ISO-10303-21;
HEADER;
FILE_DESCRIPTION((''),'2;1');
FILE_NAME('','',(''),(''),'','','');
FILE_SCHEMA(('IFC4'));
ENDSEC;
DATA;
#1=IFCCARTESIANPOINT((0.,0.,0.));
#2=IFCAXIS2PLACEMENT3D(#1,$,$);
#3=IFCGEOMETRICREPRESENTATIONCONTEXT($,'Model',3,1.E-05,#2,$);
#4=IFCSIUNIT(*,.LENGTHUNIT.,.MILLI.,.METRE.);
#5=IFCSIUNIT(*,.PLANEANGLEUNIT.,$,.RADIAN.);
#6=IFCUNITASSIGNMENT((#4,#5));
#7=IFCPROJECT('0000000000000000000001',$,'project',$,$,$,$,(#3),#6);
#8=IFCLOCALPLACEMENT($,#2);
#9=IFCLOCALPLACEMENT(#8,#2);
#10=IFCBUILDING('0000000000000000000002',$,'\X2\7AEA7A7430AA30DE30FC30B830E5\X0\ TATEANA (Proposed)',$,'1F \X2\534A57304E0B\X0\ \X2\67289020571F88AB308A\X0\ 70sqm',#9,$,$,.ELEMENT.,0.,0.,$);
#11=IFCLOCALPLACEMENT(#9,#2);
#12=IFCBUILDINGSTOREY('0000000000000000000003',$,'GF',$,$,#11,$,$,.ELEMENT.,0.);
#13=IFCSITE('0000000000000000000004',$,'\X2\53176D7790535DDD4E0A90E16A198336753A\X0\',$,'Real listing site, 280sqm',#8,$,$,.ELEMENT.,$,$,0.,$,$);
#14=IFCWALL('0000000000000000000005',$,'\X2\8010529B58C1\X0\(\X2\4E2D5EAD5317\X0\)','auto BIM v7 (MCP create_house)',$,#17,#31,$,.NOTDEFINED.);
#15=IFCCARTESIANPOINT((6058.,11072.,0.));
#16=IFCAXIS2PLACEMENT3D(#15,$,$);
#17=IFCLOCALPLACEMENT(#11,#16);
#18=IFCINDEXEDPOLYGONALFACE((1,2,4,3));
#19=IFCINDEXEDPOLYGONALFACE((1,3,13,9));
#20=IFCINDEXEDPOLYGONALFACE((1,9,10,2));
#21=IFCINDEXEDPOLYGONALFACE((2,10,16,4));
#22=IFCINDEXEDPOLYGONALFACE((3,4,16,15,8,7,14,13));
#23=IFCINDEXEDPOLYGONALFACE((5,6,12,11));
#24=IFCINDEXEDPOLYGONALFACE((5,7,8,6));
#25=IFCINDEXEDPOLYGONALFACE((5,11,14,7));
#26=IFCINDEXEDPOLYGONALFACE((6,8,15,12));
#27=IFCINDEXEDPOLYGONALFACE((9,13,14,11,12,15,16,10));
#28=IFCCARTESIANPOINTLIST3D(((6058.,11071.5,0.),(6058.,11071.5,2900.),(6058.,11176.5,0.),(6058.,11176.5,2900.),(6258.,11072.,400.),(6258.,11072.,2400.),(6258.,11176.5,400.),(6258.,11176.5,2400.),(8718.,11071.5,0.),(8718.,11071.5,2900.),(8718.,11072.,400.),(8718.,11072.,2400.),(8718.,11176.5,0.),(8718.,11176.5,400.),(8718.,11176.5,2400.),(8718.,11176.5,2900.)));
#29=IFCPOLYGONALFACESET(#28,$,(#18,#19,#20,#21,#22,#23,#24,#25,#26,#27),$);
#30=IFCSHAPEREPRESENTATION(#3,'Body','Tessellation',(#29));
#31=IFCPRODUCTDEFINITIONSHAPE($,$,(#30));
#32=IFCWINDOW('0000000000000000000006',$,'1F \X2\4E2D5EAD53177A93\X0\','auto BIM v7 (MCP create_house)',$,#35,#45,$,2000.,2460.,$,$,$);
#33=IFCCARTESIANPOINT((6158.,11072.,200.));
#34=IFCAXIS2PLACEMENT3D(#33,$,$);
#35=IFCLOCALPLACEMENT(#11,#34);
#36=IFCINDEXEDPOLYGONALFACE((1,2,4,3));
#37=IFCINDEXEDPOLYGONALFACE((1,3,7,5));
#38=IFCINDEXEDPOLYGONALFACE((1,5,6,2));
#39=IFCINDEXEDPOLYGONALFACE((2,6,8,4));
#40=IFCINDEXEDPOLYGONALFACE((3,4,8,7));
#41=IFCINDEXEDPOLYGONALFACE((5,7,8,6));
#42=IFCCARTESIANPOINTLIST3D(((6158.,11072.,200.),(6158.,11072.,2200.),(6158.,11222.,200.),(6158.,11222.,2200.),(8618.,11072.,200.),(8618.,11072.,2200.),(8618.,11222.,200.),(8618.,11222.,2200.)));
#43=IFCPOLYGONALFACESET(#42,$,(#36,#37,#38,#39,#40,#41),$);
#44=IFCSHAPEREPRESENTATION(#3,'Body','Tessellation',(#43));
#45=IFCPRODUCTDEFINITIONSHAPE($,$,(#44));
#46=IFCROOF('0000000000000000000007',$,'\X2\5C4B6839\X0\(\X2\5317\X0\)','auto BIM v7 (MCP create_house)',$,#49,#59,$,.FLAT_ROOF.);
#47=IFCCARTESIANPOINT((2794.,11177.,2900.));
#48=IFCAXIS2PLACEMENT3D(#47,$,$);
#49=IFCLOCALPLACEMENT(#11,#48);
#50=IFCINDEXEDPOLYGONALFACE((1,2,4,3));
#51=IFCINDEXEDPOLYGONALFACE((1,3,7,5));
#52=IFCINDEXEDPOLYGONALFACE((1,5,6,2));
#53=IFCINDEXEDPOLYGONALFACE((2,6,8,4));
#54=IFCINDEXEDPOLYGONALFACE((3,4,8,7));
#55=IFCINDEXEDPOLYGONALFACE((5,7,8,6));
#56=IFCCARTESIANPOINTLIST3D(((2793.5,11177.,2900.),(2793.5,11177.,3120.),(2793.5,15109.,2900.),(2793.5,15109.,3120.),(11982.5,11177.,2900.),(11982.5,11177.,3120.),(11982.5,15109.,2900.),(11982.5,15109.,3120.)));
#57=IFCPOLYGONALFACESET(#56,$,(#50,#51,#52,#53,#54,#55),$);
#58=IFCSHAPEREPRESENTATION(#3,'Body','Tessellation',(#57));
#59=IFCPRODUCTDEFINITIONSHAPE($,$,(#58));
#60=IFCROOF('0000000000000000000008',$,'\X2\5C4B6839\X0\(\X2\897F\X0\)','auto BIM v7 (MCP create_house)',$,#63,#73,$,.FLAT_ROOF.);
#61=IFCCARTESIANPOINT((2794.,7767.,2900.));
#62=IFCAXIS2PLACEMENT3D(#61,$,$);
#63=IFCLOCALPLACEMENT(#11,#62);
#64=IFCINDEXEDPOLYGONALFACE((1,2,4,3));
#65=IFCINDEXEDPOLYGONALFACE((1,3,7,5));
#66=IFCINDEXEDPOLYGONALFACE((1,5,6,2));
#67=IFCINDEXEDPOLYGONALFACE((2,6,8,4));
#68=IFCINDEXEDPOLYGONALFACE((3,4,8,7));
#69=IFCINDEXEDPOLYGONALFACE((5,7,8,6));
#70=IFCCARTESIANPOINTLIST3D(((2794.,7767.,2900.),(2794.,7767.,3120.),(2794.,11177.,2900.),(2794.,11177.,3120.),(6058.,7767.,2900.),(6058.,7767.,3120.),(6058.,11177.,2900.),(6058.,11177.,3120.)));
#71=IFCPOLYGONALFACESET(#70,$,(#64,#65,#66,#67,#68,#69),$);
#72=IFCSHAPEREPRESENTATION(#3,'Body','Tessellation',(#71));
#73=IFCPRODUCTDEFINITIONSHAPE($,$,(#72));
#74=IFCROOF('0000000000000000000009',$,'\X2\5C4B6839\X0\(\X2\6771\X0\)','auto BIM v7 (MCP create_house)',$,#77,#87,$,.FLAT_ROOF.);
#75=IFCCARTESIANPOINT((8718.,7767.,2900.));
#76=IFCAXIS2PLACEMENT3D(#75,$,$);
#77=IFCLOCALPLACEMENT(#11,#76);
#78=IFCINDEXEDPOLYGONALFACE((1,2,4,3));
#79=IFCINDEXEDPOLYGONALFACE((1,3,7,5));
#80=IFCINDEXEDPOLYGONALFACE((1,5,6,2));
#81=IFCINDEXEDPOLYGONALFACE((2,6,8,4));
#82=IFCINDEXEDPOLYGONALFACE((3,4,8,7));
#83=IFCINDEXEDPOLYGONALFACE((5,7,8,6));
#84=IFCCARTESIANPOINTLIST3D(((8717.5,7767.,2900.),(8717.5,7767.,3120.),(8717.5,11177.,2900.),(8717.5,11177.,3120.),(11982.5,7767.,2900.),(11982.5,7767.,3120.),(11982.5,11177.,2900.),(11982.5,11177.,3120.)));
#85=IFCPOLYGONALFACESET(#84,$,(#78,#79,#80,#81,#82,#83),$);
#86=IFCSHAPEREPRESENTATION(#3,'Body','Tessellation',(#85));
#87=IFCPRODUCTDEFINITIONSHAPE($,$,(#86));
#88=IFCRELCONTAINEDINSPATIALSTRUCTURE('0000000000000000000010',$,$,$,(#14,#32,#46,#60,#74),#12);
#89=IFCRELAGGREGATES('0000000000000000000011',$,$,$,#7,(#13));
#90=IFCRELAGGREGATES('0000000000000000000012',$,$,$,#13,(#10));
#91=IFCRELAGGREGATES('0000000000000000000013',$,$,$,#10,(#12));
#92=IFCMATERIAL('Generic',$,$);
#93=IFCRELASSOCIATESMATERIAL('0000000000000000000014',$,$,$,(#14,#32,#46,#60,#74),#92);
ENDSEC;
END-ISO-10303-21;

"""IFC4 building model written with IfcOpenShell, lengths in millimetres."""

from ifc_helpers import new_model, si_unit, frame, frame_2d, origin, place, context, project, spatial, rectangle, extrude, material, element, fill, save


model = new_model("IFC4")

# Units and contexts
model_context = context("Model", 3, precision=1e-05, world=origin())
ifc_project = project(units=[si_unit("LENGTHUNIT", "METRE", prefix="MILLI"), si_unit("PLANEANGLEUNIT", "RADIAN")], contexts=[model_context])

# Site, building, storey
site_placement = place(None, origin())
site = spatial("IfcSite", under=ifc_project, at=site_placement, Name="北海道川上郡標茶町", ObjectType="Real listing site, 280sqm", CompositionType="ELEMENT", RefElevation=0.0)
building_placement = place(site_placement, origin())
building = spatial("IfcBuilding", under=site, at=building_placement, Name="竪穴オマージュ TATEANA (Proposed)", ObjectType="1F 半地下 木造土被り 70sqm", CompositionType="ELEMENT", ElevationOfRefHeight=0.0, ElevationOfTerrain=0.0)
storey_placement = place(building_placement, origin())
storey = spatial("IfcBuildingStorey", under=building, at=storey_placement, Name="GF", CompositionType="ELEMENT", Elevation=0.0)

# Shared definitions
ifc_material = material(Name="Generic")

# Wall, opening, window
wall_1_placement = place(storey_placement, frame((6058.0, 11072.0, 0.0)))
wall_1 = element("IfcWall", 1, at=wall_1_placement, inside=storey, material=ifc_material, Name="耐力壁(中庭北)", Description="auto BIM v7 (MCP create_house)", PredefinedType="NOTDEFINED", context=model_context, shape_type="SweptSolid", body=[
    extrude(rectangle(XDim=2660.0, YDim=105.0, at=frame_2d((1330.0, 52.0))), frame((6058.0, 11072.0, 0.0)), (0.0, 0.0, 1.0), 2900.0),
])
opening_1_placement = place(storey_placement, frame((6158.0, 11072.0, 200.0)))
opening_1 = element("IfcOpeningElement", 2, at=opening_1_placement, cuts=wall_1, PredefinedType="NOTDEFINED", context=model_context, shape_type="SweptSolid", body=[
    extrude(rectangle(XDim=2460.0, YDim=150.0, at=frame_2d((1230.0, 75.0))), frame((6158.0, 11072.0, 200.0)), (0.0, 0.0, 1.0), 2000.0),
])
window_1_placement = place(storey_placement, frame((6158.0, 11072.0, 200.0)))
window_1 = element("IfcWindow", 3, at=window_1_placement, inside=storey, material=ifc_material, Name="1F 中庭北窓", Description="auto BIM v7 (MCP create_house)", OverallHeight=2000.0, OverallWidth=2460.0, context=model_context, shape_type="SweptSolid", body=[
    extrude(rectangle(XDim=2460.0, YDim=150.0, at=frame_2d((1230.0, 75.0))), frame((6158.0, 11072.0, 200.0)), (0.0, 0.0, 1.0), 2000.0),
])
fill(opening_1, window_1)

# Roofs
roof_1_placement = place(storey_placement, frame((2794.0, 11177.0, 2900.0)))
element("IfcRoof", 4, at=roof_1_placement, inside=storey, material=ifc_material, Name="屋根(北)", Description="auto BIM v7 (MCP create_house)", PredefinedType="FLAT_ROOF", context=model_context, shape_type="SweptSolid", body=[
    extrude(rectangle(XDim=9189.0, YDim=3932.0, at=frame_2d((4594.0, 1966.0))), frame((2794.0, 11177.0, 2900.0)), (0.0, 0.0, 1.0), 220.0),
])
roof_2_placement = place(storey_placement, frame((2794.0, 7767.0, 2900.0)))
element("IfcRoof", 5, at=roof_2_placement, inside=storey, material=ifc_material, Name="屋根(西)", Description="auto BIM v7 (MCP create_house)", PredefinedType="FLAT_ROOF", context=model_context, shape_type="SweptSolid", body=[
    extrude(rectangle(XDim=3264.0, YDim=3410.0, at=frame_2d((1632.0, 1705.0))), frame((2794.0, 7767.0, 2900.0)), (0.0, 0.0, 1.0), 220.0),
])
roof_3_placement = place(storey_placement, frame((8718.0, 7767.0, 2900.0)))
element("IfcRoof", 6, at=roof_3_placement, inside=storey, material=ifc_material, Name="屋根(東)", Description="auto BIM v7 (MCP create_house)", PredefinedType="FLAT_ROOF", context=model_context, shape_type="SweptSolid", body=[
    extrude(rectangle(XDim=3265.0, YDim=3410.0, at=frame_2d((1632.0, 1705.0))), frame((8718.0, 7767.0, 2900.0)), (0.0, 0.0, 1.0), 220.0),
])

save(model, "model.ifc")
